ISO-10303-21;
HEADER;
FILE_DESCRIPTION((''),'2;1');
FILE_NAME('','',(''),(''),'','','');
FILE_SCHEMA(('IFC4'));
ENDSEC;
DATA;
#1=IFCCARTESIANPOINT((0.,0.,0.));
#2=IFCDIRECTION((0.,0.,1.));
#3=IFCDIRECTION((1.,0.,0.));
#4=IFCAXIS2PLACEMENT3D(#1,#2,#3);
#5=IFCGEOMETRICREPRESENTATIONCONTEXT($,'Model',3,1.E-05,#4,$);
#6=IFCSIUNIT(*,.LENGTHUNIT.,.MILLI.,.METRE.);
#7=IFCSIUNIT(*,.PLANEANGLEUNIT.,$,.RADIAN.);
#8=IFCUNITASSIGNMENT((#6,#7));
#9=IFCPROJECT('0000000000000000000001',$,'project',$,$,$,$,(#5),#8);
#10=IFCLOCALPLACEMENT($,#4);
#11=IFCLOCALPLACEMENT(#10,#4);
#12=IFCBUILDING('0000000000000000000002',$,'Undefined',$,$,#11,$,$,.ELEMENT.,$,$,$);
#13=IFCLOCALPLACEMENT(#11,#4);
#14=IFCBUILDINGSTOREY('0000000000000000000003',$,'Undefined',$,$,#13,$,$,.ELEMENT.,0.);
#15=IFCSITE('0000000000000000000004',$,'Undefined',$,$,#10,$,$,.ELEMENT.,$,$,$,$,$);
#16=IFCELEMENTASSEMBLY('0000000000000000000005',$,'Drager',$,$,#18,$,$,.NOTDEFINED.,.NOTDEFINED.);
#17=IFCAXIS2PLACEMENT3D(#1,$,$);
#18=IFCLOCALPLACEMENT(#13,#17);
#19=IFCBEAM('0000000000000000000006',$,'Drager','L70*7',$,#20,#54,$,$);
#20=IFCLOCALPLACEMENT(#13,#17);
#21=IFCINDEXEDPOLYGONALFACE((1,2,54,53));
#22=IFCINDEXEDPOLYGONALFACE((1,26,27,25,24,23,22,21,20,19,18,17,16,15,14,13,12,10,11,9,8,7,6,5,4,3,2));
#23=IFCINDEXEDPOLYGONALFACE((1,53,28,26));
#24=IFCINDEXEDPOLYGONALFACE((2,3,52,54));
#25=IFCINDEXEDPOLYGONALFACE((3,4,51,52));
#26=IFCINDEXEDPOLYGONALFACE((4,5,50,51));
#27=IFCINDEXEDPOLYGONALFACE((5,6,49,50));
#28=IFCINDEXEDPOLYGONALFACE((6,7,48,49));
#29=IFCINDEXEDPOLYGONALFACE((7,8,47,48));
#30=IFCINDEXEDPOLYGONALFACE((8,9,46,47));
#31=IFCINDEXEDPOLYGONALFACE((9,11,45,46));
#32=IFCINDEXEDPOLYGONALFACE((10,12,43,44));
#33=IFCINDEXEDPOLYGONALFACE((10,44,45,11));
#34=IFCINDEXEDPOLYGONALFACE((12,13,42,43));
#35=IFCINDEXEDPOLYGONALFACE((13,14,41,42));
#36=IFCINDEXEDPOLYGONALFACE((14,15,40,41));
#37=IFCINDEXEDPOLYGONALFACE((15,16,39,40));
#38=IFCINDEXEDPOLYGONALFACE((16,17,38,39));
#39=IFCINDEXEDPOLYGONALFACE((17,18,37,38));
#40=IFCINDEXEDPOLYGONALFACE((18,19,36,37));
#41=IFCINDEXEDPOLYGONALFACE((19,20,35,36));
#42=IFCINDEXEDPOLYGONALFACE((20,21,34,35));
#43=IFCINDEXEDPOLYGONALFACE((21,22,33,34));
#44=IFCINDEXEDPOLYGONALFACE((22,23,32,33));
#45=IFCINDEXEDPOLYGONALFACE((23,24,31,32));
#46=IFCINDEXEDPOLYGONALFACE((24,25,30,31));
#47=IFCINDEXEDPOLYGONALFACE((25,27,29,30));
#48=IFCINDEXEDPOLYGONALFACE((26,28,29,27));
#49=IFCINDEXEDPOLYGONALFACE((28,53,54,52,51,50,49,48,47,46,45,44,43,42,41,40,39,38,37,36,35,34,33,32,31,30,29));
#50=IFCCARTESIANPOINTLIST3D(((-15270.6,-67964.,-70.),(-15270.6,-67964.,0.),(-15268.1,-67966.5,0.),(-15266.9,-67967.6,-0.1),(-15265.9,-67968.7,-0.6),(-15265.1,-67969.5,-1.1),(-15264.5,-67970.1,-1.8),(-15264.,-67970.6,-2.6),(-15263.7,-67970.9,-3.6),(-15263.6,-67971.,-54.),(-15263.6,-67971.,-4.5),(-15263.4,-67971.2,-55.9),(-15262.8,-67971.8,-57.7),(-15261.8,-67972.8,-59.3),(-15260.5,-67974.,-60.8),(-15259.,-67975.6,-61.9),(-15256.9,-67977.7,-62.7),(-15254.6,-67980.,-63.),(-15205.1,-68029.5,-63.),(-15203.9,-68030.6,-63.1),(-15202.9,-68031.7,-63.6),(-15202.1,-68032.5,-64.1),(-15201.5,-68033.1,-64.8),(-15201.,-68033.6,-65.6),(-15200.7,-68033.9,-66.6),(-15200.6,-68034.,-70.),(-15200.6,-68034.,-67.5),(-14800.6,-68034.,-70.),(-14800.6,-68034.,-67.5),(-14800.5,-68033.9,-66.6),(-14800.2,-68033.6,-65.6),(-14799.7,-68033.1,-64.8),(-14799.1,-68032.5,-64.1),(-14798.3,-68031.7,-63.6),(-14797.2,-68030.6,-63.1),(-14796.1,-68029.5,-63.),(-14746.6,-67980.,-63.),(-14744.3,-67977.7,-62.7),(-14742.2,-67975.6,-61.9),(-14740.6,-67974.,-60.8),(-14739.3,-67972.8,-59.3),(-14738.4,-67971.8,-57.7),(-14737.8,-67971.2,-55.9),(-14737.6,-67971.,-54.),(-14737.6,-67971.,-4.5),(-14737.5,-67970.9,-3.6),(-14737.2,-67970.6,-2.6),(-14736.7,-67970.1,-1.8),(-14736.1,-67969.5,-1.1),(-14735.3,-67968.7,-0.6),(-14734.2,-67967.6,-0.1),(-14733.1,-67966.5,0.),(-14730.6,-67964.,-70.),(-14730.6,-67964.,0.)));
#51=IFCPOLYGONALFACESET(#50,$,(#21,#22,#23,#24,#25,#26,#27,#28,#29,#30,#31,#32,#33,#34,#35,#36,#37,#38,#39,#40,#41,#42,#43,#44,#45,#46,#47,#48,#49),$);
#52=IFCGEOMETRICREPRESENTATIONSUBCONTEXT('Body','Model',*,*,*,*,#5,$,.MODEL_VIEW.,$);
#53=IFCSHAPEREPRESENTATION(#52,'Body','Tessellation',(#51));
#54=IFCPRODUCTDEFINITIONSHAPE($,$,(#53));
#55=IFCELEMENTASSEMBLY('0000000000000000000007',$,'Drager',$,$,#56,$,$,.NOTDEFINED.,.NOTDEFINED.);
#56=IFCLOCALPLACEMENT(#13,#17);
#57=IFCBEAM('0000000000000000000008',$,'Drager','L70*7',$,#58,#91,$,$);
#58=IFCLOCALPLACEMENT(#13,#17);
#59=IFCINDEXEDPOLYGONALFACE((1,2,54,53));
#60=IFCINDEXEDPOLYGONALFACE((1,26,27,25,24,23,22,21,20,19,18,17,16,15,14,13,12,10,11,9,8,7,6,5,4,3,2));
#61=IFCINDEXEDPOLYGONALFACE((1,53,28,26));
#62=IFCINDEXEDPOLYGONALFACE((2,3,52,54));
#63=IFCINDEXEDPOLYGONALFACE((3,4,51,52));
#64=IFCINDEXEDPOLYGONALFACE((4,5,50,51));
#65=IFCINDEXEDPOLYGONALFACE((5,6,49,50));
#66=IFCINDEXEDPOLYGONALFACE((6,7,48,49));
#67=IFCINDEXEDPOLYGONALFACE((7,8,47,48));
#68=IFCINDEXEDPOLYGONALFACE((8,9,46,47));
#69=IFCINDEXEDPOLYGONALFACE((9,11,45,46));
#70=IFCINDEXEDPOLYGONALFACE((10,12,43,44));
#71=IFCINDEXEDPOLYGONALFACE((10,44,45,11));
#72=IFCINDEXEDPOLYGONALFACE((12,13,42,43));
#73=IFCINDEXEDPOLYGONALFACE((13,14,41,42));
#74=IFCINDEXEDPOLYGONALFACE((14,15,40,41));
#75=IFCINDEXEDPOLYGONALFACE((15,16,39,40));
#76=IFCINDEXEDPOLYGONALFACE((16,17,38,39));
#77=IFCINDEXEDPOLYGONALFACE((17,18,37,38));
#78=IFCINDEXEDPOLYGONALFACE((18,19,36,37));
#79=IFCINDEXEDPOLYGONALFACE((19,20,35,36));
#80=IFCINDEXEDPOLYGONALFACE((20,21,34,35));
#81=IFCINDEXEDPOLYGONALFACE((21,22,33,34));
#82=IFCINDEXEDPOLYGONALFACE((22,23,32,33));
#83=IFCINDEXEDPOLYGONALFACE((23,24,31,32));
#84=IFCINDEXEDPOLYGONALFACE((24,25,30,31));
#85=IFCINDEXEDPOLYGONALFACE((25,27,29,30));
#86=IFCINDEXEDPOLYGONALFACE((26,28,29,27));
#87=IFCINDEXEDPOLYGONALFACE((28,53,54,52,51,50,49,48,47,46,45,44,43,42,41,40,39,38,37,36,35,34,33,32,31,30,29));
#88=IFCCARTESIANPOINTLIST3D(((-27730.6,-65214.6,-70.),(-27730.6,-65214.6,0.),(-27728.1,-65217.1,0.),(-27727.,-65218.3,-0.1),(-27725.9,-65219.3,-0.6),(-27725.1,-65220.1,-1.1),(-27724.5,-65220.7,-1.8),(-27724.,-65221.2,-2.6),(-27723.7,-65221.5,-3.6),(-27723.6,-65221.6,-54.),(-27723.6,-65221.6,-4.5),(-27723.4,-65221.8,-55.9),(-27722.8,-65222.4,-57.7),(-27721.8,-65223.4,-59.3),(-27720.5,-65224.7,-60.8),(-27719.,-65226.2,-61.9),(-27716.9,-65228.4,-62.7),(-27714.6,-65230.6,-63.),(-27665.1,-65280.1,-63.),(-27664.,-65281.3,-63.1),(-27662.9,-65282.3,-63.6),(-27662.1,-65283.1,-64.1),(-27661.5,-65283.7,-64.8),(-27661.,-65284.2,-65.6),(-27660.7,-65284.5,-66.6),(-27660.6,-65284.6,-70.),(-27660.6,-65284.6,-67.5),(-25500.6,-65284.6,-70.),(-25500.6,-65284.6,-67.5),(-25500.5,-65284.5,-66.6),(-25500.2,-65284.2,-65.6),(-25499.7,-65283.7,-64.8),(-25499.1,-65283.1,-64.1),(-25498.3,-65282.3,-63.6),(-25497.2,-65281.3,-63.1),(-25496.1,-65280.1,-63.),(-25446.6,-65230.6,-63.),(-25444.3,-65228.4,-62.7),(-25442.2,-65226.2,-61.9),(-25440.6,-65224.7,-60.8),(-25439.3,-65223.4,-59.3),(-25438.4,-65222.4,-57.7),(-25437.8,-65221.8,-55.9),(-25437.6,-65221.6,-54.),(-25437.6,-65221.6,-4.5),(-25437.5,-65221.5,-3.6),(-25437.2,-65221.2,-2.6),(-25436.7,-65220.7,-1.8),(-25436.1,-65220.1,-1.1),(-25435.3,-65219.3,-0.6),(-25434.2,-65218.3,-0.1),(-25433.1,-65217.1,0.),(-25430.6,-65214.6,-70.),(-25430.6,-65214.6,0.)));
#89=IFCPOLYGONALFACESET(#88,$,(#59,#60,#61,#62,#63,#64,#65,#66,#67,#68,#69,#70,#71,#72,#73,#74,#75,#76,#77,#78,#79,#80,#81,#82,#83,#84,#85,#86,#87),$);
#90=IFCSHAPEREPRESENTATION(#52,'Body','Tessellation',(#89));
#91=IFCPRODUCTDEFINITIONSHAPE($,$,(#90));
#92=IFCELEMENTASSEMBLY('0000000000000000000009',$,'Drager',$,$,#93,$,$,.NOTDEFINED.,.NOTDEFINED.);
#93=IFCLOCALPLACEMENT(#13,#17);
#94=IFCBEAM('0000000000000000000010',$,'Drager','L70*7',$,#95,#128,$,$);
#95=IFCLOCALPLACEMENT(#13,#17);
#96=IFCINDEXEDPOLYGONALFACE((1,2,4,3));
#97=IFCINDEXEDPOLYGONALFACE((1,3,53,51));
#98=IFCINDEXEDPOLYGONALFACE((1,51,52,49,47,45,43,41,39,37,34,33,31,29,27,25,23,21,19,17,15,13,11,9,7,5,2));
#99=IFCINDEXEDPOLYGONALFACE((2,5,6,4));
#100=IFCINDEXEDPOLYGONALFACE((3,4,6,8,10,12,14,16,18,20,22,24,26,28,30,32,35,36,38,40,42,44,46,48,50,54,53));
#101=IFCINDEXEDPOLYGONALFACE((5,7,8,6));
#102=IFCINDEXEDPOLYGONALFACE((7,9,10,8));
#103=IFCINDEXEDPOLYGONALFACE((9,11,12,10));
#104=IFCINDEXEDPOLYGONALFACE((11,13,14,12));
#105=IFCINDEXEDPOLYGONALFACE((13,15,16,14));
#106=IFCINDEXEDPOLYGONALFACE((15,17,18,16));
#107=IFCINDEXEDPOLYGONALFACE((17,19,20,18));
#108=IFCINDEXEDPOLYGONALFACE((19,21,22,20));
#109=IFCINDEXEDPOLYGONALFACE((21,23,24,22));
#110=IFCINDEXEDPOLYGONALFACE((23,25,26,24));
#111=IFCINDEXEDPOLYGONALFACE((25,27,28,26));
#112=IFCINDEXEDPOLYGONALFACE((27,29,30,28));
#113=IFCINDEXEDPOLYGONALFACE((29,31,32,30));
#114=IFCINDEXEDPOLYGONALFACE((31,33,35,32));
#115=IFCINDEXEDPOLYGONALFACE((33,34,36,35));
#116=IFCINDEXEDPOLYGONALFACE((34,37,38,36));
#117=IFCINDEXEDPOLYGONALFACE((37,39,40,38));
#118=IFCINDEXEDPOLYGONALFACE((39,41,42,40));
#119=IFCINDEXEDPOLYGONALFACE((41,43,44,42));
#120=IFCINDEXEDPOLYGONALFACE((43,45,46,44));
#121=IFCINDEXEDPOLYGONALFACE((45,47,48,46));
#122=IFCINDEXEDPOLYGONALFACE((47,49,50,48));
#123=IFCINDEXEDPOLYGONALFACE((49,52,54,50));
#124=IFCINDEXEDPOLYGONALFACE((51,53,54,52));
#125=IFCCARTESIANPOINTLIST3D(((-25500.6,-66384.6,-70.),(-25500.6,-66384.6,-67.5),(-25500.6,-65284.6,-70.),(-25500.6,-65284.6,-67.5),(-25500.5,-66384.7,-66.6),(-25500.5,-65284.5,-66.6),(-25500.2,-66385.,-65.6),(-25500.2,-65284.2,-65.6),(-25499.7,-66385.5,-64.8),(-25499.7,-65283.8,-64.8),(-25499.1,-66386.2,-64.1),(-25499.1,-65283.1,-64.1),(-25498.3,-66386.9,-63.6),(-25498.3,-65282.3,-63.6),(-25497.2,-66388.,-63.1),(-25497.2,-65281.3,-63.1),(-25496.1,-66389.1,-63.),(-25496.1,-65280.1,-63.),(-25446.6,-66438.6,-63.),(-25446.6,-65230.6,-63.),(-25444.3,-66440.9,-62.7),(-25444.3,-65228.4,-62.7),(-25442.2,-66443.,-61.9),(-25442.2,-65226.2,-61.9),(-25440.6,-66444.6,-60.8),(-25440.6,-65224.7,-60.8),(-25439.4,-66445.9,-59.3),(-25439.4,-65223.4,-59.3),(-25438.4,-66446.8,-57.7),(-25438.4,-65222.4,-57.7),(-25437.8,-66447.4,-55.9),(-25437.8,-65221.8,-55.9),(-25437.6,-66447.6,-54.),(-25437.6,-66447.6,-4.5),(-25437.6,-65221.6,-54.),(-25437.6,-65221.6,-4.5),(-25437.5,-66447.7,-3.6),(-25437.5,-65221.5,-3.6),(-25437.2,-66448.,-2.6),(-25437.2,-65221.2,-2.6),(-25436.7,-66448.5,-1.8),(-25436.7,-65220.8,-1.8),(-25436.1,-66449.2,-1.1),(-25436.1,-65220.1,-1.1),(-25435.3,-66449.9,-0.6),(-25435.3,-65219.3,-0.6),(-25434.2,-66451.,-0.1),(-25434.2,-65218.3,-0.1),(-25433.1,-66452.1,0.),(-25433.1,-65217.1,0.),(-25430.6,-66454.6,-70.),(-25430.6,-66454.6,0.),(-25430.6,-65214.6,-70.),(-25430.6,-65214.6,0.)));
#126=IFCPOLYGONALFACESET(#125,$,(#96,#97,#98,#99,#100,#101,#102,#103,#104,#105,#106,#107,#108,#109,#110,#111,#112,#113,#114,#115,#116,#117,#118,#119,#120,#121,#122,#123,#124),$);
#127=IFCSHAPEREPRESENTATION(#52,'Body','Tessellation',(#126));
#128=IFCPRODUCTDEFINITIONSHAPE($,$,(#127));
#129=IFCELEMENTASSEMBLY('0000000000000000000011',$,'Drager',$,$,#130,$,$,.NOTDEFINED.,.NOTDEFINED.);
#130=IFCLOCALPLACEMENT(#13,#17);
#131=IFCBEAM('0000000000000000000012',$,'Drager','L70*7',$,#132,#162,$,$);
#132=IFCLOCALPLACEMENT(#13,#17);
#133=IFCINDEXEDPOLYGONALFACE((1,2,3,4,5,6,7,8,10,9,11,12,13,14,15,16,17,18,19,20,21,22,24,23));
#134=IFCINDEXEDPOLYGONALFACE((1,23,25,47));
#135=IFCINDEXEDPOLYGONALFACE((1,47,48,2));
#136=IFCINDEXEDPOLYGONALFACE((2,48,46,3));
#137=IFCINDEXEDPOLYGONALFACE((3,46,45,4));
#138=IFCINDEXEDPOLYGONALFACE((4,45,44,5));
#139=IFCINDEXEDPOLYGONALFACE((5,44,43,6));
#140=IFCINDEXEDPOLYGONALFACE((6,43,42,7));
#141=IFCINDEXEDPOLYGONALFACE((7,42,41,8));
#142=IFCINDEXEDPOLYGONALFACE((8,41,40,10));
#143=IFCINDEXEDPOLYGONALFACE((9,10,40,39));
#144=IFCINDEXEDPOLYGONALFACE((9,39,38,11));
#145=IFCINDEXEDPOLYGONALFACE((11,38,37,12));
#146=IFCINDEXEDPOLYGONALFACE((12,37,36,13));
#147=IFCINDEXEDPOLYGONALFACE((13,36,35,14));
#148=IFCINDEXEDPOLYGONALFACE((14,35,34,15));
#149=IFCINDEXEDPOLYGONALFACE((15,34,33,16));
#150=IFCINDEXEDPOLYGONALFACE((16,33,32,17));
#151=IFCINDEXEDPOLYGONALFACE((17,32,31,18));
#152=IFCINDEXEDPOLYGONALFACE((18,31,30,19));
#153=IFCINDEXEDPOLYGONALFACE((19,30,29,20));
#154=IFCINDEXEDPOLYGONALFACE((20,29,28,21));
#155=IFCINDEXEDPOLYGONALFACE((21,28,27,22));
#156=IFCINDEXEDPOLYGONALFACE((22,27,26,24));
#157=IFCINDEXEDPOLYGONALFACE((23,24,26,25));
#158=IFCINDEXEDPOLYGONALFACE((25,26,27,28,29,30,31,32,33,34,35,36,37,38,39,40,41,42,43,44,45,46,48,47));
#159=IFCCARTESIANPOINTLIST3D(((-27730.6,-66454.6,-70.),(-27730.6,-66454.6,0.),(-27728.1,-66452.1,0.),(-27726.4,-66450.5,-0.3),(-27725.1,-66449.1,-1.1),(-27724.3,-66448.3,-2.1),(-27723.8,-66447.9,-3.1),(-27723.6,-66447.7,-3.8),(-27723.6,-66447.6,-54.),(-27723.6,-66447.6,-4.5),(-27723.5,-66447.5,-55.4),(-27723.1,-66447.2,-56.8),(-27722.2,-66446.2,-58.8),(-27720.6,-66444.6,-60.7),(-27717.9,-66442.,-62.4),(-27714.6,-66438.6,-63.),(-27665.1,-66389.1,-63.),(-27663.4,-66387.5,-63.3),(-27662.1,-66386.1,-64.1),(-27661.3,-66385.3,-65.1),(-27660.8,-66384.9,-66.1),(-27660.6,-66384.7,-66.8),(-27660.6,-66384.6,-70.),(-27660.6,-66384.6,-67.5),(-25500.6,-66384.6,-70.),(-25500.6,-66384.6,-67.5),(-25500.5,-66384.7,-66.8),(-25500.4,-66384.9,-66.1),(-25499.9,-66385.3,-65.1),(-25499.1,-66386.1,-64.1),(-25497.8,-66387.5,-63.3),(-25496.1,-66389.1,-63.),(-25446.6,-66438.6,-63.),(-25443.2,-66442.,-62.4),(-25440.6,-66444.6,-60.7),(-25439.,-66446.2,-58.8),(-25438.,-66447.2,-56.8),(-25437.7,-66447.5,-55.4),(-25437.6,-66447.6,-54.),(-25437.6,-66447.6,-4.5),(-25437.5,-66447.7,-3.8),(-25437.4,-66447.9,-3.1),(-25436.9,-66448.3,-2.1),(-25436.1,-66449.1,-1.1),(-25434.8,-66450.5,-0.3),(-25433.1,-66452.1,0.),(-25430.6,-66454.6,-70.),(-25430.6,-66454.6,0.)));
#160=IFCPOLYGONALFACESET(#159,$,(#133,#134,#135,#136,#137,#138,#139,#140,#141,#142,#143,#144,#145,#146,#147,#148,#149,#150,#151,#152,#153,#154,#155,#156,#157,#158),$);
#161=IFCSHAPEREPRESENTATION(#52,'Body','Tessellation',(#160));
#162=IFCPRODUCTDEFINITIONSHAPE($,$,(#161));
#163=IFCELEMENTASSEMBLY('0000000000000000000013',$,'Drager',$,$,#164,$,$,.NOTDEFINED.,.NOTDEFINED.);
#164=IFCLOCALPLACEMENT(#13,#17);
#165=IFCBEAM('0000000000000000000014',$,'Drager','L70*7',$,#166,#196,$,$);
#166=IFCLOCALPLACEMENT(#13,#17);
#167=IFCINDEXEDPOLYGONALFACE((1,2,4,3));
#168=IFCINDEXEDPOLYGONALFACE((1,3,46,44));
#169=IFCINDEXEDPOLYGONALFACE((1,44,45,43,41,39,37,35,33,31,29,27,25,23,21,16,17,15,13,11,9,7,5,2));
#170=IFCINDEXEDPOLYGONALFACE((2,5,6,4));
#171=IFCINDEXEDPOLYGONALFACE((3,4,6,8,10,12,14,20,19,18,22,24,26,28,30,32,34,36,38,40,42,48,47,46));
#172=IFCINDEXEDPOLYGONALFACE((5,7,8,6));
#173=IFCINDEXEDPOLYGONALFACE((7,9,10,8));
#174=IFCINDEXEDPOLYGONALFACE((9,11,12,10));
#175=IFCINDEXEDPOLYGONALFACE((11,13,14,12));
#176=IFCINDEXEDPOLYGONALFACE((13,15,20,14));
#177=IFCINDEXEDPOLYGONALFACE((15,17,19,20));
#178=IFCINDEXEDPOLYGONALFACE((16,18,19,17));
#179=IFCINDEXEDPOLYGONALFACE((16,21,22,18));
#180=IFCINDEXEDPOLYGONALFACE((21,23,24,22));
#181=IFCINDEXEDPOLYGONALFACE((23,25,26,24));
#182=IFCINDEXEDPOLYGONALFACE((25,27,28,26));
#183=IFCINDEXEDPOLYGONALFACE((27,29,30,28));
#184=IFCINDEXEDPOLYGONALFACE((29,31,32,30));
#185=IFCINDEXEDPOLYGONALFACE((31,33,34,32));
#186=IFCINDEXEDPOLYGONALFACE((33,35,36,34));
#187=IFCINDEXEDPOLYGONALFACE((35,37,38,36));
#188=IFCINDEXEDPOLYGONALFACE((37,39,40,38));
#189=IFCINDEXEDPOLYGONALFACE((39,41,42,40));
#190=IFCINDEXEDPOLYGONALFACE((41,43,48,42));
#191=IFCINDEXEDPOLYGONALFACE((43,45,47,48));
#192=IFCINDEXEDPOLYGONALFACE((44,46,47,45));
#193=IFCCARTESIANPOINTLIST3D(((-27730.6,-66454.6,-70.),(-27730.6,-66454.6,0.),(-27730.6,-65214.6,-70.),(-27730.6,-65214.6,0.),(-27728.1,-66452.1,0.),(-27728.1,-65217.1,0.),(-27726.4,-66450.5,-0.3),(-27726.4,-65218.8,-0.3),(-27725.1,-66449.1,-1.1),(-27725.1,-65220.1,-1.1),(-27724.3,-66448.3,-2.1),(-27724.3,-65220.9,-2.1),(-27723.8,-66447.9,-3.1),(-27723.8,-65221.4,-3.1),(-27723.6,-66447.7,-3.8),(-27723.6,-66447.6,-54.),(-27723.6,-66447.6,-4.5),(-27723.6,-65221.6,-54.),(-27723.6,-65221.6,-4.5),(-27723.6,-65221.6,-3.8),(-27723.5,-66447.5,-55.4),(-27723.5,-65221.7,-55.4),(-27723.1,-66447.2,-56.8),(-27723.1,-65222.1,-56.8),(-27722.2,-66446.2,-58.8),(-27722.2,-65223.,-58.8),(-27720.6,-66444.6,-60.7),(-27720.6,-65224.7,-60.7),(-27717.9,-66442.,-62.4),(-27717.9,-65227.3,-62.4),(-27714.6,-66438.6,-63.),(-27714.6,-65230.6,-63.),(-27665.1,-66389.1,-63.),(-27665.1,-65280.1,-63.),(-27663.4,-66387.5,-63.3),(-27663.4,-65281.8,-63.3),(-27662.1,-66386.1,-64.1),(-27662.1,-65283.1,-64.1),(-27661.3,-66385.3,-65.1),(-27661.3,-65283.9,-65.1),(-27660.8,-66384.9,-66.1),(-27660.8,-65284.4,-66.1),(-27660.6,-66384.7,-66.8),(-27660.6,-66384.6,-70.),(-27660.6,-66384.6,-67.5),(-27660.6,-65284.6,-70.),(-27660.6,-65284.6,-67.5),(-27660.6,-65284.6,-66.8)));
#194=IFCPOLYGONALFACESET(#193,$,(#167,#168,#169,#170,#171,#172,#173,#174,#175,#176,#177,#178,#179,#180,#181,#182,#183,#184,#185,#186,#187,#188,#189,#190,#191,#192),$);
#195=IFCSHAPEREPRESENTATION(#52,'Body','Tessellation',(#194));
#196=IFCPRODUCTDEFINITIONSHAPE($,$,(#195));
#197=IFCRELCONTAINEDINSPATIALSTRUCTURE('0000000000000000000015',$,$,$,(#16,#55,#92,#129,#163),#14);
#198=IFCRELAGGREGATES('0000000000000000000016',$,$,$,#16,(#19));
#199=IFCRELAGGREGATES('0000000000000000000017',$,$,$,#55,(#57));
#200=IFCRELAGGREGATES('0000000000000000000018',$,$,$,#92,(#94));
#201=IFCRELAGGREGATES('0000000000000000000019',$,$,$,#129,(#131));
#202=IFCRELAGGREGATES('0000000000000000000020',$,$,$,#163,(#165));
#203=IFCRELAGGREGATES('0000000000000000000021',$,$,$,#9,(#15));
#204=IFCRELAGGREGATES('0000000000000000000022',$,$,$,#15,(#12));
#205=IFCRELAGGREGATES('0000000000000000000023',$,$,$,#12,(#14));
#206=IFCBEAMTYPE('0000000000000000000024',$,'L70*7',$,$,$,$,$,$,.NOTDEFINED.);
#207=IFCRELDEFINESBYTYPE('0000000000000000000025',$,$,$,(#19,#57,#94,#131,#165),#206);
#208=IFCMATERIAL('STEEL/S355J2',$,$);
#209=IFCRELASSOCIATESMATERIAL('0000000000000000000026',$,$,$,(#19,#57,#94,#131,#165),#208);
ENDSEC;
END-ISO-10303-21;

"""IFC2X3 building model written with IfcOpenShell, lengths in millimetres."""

from ifc_helpers import new_model, si_unit, frame, origin_with_axes, origin_2d_with_axis, place, context, subcontext, project, spatial, l_section, extrude, clip, halfspace, material, type_object, element, aggregate, save


model = new_model("IFC2X3")

# Units and contexts
model_context = context("Model", 3, precision=1e-05, world=origin_with_axes())
body_context = subcontext(model_context, "Body", "Model", "MODEL_VIEW")
ifc_project = project(units=[si_unit("LENGTHUNIT", "METRE", prefix="MILLI"), si_unit("PLANEANGLEUNIT", "RADIAN")], contexts=[model_context])

# Site, building, storey
site_placement = place(None, origin_with_axes())
site = spatial("IfcSite", under=ifc_project, at=site_placement, Name="Undefined", CompositionType="ELEMENT")
building_placement = place(site_placement, origin_with_axes())
building = spatial("IfcBuilding", under=site, at=building_placement, Name="Undefined", CompositionType="ELEMENT")
storey_placement = place(building_placement, origin_with_axes())
storey = spatial("IfcBuildingStorey", under=building, at=storey_placement, Name="Undefined", CompositionType="ELEMENT", Elevation=0.0)

# Element assemblies, beams
assembly_1_placement = place(storey_placement, origin_with_axes())
assembly_1 = element("IfcElementAssembly", 1, at=assembly_1_placement, inside=storey, Name="Drager", AssemblyPlace="NOTDEFINED", PredefinedType="NOTDEFINED")
ifc_material_1 = material(Name="STEEL/S355J2")
beam_type_1 = type_object("IfcBeamType", Name="L70*7", PredefinedType="NOTDEFINED")
beam_1_placement = place(assembly_1_placement, frame((-15200.6, -67999.0, -35.0), z_axis=(0.0, 0.0, 1.0), x_axis=(1.0, 0.0, 0.0)))
beam_1 = element("IfcBeam", 2, at=beam_1_placement, type_object=beam_type_1, material=ifc_material_1, Name="Drager", Description="L70*7", context=body_context, shape_type="Clipping", body=[
    clip(clip(extrude(l_section(Depth=70.0, Width=70.0, Thickness=7.0, FilletRadius=9.0, EdgeRadius=4.5, at=origin_2d_with_axis()), frame((505.7, 0.0, 0.0), z_axis=(-1.0, 0.0, 0.0), x_axis=(0.0, -1.0, 0.0)), (0.0, 0.0, 1.0), 611.4), halfspace(frame((400.0, -35.0, 35.0), z_axis=(-0.707107, 0.707107, 0.0), x_axis=(0.707107, 0.707107, 0.0)), True)), halfspace(frame((0.0, -35.0, 35.0), z_axis=(-0.707107, -0.707107, 0.0), x_axis=(-0.707107, 0.707107, 0.0)), False)),
])
aggregate(assembly_1, [beam_1])
assembly_2_placement = place(storey_placement, origin_with_axes())
assembly_2 = element("IfcElementAssembly", 3, at=assembly_2_placement, inside=storey, Name="Drager", AssemblyPlace="NOTDEFINED", PredefinedType="NOTDEFINED")
beam_2_placement = place(assembly_2_placement, frame((-27660.6, -65249.6, -35.0), z_axis=(0.0, 0.0, 1.0), x_axis=(1.0, 0.0, 0.0)))
beam_2 = element("IfcBeam", 4, at=beam_2_placement, type_object=beam_type_1, material=ifc_material_1, Name="Drager", Description="L70*7", context=body_context, shape_type="Clipping", body=[
    clip(clip(extrude(l_section(Depth=70.0, Width=70.0, Thickness=7.0, FilletRadius=9.0, EdgeRadius=4.5, at=origin_2d_with_axis()), frame((2265.7, 0.0, 0.0), z_axis=(-1.0, 0.0, 0.0), x_axis=(0.0, -1.0, 0.0)), (0.0, 0.0, 1.0), 2371.4), halfspace(frame((2160.0, -35.0, 35.0), z_axis=(-0.707107, 0.707107, 0.0), x_axis=(0.707107, 0.707107, 0.0)), True)), halfspace(frame((0.0, -35.0, 35.0), z_axis=(-0.707107, -0.707107, 0.0), x_axis=(-0.707107, 0.707107, 0.0)), False)),
])
aggregate(assembly_2, [beam_2])
assembly_3_placement = place(storey_placement, origin_with_axes())
assembly_3 = element("IfcElementAssembly", 5, at=assembly_3_placement, inside=storey, Name="Drager", AssemblyPlace="NOTDEFINED", PredefinedType="NOTDEFINED")
beam_3_placement = place(assembly_3_placement, frame((-25465.6, -65284.6, -35.0), z_axis=(0.0, 0.0, 1.0), x_axis=(0.0, -1.0, 0.0)))
beam_3 = element("IfcBeam", 6, at=beam_3_placement, type_object=beam_type_1, material=ifc_material_1, Name="Drager", Description="L70*7", context=body_context, shape_type="Clipping", body=[
    clip(clip(extrude(l_section(Depth=70.0, Width=70.0, Thickness=7.0, FilletRadius=9.0, EdgeRadius=4.5, at=origin_2d_with_axis()), frame((1205.7, 0.0, 0.0), z_axis=(-1.0, 0.0, 0.0), x_axis=(0.0, -1.0, 0.0)), (0.0, 0.0, 1.0), 1311.4), halfspace(frame((1100.0, -35.0, 35.0), z_axis=(-0.707107, 0.707107, 0.0), x_axis=(0.707107, 0.707107, 0.0)), True)), halfspace(frame((0.0, -35.0, 35.0), z_axis=(-0.707107, -0.707107, 0.0), x_axis=(-0.707107, 0.707107, 0.0)), False)),
])
aggregate(assembly_3, [beam_3])
assembly_4_placement = place(storey_placement, origin_with_axes())
assembly_4 = element("IfcElementAssembly", 7, at=assembly_4_placement, inside=storey, Name="Drager", AssemblyPlace="NOTDEFINED", PredefinedType="NOTDEFINED")
beam_4_placement = place(assembly_4_placement, frame((-25500.6, -66419.6, -35.0), z_axis=(0.0, 0.0, 1.0), x_axis=(-1.0, 0.0, 0.0)))
beam_4 = element("IfcBeam", 8, at=beam_4_placement, type_object=beam_type_1, material=ifc_material_1, Name="Drager", Description="L70*7", context=body_context, shape_type="Clipping", body=[
    clip(clip(extrude(l_section(Depth=70.0, Width=70.0, Thickness=7.0, FilletRadius=9.0, EdgeRadius=4.5, at=origin_2d_with_axis()), frame((2265.7, 0.0, 0.0), z_axis=(-1.0, 0.0, 0.0), x_axis=(0.0, -1.0, 0.0)), (0.0, 0.0, 1.0), 2371.4), halfspace(frame((2160.0, -35.0, 35.0), z_axis=(0.707107, -0.707107, 0.0), x_axis=(0.0, 0.0, 1.0)), False)), halfspace(frame((0.0, -35.0, 35.0), z_axis=(0.707107, 0.707107, 0.0), x_axis=(0.0, 0.0, 1.0)), True)),
])
aggregate(assembly_4, [beam_4])
assembly_5_placement = place(storey_placement, origin_with_axes())
assembly_5 = element("IfcElementAssembly", 9, at=assembly_5_placement, inside=storey, Name="Drager", AssemblyPlace="NOTDEFINED", PredefinedType="NOTDEFINED")
beam_5_placement = place(assembly_5_placement, frame((-27695.6, -66384.6, -35.0), z_axis=(0.0, 0.0, 1.0), x_axis=(0.0, 1.0, 0.0)))
beam_5 = element("IfcBeam", 10, at=beam_5_placement, type_object=beam_type_1, material=ifc_material_1, Name="Drager", Description="L70*7", context=body_context, shape_type="Clipping", body=[
    clip(clip(extrude(l_section(Depth=70.0, Width=70.0, Thickness=7.0, FilletRadius=9.0, EdgeRadius=4.5, at=origin_2d_with_axis()), frame((1205.7, 0.0, 0.0), z_axis=(-1.0, 0.0, 0.0), x_axis=(0.0, -1.0, 0.0)), (0.0, 0.0, 1.0), 1311.4), halfspace(frame((1100.0, -35.0, 35.0), z_axis=(0.707107, -0.707107, 0.0), x_axis=(0.0, 0.0, 1.0)), False)), halfspace(frame((0.0, -35.0, 35.0), z_axis=(0.707107, 0.707107, 0.0), x_axis=(0.0, 0.0, 1.0)), True)),
])
aggregate(assembly_5, [beam_5])

save(model, "model.ifc")
